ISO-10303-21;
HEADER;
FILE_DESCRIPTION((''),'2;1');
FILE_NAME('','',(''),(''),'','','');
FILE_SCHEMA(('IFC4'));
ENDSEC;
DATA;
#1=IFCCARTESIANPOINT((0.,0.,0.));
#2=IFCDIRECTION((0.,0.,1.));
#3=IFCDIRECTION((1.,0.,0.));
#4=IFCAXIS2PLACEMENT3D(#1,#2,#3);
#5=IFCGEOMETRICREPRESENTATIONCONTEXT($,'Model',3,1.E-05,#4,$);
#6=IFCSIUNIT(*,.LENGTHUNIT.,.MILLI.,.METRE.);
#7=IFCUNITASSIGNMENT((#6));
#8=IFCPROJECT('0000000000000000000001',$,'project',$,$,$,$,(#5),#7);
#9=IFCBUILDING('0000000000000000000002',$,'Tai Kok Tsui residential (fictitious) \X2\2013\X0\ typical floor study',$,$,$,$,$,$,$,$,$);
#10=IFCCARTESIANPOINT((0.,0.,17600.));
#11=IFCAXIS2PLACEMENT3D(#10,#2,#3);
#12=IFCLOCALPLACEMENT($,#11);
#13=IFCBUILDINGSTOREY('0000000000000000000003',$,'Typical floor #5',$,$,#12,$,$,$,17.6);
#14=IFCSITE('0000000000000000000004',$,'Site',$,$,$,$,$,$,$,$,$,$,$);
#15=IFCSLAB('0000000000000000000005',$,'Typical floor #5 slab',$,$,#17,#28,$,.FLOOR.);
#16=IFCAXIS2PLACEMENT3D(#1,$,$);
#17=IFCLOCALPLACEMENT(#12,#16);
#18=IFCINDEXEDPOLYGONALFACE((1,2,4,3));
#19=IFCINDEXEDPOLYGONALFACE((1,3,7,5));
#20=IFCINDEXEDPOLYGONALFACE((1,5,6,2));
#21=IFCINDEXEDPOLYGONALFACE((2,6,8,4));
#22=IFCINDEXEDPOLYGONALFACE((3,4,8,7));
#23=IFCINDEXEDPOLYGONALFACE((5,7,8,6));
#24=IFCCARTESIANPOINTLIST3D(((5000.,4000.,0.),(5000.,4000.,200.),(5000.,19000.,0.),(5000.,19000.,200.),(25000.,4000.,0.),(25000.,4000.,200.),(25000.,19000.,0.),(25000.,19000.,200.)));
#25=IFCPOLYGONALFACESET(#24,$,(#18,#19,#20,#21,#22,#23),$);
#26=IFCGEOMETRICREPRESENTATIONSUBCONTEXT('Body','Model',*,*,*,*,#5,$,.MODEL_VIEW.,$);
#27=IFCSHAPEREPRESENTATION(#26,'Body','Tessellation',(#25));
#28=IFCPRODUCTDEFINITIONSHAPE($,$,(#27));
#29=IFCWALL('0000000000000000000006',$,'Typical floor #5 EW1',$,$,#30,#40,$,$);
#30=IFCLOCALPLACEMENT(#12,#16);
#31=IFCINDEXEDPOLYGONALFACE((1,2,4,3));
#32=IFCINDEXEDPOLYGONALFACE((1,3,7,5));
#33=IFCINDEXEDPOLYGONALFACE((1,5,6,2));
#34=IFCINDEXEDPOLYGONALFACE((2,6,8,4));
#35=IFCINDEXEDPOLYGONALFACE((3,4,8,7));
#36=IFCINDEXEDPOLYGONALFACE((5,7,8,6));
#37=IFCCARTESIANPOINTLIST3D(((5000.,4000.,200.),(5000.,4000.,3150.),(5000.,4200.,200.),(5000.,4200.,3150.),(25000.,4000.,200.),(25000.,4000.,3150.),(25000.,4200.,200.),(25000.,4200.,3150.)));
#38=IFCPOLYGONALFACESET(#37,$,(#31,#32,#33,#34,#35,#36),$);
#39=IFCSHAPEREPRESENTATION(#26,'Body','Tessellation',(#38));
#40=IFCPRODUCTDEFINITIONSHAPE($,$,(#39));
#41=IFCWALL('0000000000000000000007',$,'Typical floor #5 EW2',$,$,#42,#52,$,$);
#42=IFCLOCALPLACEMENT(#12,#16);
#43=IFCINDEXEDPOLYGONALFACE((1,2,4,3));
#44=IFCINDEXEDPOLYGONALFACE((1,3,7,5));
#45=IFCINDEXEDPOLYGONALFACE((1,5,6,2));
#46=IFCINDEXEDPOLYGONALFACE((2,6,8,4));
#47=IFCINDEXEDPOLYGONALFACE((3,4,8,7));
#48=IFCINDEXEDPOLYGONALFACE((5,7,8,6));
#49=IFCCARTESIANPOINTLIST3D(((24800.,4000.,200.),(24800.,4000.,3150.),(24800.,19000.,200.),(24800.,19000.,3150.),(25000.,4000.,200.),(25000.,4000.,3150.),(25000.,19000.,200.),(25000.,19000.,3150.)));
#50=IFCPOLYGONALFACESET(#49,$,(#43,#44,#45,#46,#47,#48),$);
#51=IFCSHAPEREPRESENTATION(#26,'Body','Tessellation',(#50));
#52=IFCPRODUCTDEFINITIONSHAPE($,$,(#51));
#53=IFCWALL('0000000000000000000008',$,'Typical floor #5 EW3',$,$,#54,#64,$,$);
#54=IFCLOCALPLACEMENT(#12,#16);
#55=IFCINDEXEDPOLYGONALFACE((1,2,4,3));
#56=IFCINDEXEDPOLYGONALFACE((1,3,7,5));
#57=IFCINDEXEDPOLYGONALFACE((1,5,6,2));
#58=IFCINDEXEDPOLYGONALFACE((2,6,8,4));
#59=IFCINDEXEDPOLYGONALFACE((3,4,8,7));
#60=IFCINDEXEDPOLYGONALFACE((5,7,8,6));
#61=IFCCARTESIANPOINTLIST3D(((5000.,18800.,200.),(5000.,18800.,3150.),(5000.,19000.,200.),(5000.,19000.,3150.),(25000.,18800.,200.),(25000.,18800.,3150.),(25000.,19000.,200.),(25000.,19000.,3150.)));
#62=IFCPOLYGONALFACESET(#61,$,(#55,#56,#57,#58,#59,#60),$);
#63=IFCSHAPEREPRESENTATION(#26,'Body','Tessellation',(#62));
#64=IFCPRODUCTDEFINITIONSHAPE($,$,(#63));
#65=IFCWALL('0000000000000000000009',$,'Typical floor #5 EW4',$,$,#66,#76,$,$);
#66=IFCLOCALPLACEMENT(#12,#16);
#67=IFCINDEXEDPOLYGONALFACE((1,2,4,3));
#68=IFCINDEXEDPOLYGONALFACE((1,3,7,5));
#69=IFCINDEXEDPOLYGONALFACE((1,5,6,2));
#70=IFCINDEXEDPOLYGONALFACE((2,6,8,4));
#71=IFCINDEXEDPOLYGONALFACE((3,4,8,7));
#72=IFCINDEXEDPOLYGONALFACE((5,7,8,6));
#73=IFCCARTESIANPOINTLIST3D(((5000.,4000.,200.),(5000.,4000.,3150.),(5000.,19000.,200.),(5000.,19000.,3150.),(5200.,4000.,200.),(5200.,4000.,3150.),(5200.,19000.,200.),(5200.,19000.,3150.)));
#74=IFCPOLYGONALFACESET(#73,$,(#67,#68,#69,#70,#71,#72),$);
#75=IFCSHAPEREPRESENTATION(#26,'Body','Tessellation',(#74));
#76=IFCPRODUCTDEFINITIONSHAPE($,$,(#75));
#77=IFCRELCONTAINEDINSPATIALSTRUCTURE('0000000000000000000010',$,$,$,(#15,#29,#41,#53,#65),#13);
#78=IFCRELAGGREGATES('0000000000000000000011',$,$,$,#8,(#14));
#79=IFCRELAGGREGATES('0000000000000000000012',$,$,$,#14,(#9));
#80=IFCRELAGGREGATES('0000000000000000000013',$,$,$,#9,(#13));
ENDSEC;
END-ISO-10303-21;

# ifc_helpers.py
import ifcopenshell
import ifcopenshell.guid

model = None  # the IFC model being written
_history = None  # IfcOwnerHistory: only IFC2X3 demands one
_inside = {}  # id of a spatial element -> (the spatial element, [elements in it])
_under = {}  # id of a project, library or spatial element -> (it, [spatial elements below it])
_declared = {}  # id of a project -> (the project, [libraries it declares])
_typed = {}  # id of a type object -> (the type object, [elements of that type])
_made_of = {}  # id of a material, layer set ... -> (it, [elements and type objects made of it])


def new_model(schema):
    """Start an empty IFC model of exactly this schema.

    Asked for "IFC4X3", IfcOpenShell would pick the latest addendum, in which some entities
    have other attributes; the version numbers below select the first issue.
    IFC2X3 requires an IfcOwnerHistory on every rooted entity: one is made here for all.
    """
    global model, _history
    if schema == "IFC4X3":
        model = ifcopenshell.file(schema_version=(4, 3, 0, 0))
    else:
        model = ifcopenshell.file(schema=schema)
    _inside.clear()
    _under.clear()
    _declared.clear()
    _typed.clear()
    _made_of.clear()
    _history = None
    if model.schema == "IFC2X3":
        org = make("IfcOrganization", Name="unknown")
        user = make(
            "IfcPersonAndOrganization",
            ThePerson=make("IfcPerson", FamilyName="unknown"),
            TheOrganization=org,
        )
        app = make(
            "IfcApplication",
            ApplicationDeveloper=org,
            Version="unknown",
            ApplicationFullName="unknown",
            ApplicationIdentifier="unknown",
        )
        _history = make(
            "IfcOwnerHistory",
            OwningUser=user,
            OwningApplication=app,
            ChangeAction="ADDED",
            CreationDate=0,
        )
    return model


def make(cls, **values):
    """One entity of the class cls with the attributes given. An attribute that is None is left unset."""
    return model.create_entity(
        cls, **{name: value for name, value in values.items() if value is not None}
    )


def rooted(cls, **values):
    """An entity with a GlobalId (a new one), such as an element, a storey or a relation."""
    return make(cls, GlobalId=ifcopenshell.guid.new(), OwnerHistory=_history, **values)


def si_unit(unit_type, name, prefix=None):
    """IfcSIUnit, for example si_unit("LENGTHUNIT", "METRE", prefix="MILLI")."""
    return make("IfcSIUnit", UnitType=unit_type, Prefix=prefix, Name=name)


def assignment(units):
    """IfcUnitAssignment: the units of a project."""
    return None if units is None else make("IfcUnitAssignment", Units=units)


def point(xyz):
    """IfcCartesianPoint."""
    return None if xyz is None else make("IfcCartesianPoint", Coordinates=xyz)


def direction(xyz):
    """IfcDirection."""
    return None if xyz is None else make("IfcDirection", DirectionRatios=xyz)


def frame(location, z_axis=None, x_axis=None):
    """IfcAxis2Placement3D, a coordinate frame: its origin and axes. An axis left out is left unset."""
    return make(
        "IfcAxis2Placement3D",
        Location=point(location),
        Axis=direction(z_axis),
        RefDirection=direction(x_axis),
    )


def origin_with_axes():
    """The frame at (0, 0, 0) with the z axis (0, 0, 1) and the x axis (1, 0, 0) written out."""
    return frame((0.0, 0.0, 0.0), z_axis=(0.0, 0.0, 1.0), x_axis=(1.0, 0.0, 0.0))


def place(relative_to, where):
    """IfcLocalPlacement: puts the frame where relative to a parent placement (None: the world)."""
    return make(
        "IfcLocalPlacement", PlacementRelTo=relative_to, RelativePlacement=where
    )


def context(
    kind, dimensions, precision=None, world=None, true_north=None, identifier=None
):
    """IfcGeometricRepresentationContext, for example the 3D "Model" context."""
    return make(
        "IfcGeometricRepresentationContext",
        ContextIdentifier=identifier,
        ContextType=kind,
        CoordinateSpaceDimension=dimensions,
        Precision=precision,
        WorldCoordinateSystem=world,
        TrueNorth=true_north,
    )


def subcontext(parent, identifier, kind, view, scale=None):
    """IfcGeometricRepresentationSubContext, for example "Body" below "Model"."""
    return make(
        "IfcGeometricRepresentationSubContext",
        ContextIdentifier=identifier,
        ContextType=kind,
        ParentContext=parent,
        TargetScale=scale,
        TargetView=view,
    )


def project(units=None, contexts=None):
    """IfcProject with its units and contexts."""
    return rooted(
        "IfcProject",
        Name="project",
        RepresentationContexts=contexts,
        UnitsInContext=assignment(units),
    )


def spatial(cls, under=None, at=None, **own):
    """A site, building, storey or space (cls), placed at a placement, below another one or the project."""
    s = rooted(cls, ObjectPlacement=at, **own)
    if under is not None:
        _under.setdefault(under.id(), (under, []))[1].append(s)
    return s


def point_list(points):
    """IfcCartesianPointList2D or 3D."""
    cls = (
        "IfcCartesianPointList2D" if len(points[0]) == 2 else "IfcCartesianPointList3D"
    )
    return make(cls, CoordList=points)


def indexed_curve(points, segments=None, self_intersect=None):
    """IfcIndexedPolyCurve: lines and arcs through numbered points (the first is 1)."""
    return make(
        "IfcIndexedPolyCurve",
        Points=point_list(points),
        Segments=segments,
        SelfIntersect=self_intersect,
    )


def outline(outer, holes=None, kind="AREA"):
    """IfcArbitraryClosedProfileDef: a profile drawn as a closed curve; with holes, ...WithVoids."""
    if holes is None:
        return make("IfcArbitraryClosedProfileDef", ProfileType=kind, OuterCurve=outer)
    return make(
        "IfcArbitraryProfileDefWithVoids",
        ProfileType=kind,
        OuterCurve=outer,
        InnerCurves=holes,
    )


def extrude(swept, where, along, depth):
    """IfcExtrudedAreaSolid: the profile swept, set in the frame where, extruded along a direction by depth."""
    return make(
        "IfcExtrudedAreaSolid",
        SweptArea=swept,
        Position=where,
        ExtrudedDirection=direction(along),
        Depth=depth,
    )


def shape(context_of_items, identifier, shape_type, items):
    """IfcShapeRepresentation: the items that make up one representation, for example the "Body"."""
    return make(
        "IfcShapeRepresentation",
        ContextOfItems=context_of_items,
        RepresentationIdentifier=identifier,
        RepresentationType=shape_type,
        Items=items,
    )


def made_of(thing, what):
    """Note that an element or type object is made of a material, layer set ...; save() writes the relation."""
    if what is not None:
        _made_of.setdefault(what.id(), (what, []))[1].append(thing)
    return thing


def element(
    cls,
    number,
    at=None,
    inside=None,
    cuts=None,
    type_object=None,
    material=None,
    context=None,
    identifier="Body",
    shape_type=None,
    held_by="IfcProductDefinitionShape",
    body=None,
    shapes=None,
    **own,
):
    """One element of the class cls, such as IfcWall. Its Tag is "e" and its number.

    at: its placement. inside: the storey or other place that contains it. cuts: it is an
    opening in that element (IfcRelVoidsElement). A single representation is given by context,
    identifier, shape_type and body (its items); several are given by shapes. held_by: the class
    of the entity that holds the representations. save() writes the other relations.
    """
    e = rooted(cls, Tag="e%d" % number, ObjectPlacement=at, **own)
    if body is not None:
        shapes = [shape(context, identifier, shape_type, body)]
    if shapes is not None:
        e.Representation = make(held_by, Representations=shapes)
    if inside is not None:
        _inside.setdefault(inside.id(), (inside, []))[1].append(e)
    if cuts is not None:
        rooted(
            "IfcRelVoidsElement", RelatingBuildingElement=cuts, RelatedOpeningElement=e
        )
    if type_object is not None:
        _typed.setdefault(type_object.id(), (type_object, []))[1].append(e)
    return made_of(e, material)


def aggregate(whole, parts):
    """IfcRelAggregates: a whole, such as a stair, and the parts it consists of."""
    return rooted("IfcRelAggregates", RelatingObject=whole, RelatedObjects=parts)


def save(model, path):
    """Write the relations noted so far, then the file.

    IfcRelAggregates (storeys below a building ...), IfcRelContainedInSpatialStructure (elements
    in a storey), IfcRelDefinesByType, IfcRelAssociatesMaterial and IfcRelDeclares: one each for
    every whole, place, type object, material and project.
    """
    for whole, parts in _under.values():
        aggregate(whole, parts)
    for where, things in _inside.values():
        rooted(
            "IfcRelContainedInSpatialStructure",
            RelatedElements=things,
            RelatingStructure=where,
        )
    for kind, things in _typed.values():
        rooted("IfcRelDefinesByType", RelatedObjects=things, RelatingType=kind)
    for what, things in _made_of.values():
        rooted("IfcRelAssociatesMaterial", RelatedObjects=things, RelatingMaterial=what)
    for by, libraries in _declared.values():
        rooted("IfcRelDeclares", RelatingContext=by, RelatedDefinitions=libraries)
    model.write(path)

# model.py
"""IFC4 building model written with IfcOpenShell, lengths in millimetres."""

from ifc_helpers import new_model, si_unit, frame, origin_with_axes, place, context, subcontext, project, spatial, indexed_curve, outline, extrude, element, save


model = new_model("IFC4")

# Units and contexts
model_context = context("Model", 3, precision=1e-05, world=origin_with_axes())
body_context = subcontext(model_context, "Body", "Model", "MODEL_VIEW")
ifc_project = project(units=[si_unit("LENGTHUNIT", "METRE", prefix="MILLI")], contexts=[model_context])

# Site, building, storey
site = spatial("IfcSite", under=ifc_project, Name="Site")
building = spatial("IfcBuilding", under=site, Name="Tai Kok Tsui residential (fictitious) – typical floor study")
storey_placement = place(None, frame((0.0, 0.0, 17600.0), z_axis=(0.0, 0.0, 1.0), x_axis=(1.0, 0.0, 0.0)))
storey = spatial("IfcBuildingStorey", under=building, at=storey_placement, Name="Typical floor #5", Elevation=17.6)

# Slab
slab_placement = place(storey_placement, origin_with_axes())
element("IfcSlab", 1, at=slab_placement, inside=storey, Name="Typical floor #5 slab", PredefinedType="FLOOR", context=body_context, shape_type="SweptSolid", body=[
    extrude(outline(indexed_curve([(5000.0, 4000.0), (25000.0, 4000.0), (25000.0, 19000.0), (5000.0, 19000.0)])), None, (0.0, 0.0, 1.0), 200.0),
])

# Walls
wall_1_placement = place(storey_placement, frame((5000.0, 4000.0, 200.0), z_axis=(0.0, 0.0, 1.0), x_axis=(1.0, 0.0, 0.0)))
element("IfcWall", 2, at=wall_1_placement, inside=storey, Name="Typical floor #5 EW1", context=body_context, shape_type="SweptSolid", body=[
    extrude(outline(indexed_curve([(0.0, 0.0), (0.0, 200.0), (20000.0, 200.0), (20000.0, 0.0), (0.0, 0.0)], self_intersect=False)), origin_with_axes(), (0.0, 0.0, 1.0), 2950.0),
])
wall_2_placement = place(storey_placement, frame((25000.0, 4000.0, 200.0), z_axis=(0.0, 0.0, 1.0), x_axis=(0.0, 1.0, 0.0)))
element("IfcWall", 3, at=wall_2_placement, inside=storey, Name="Typical floor #5 EW2", context=body_context, shape_type="SweptSolid", body=[
    extrude(outline(indexed_curve([(0.0, 0.0), (0.0, 200.0), (15000.0, 200.0), (15000.0, 0.0), (0.0, 0.0)], self_intersect=False)), origin_with_axes(), (0.0, 0.0, 1.0), 2950.0),
])
wall_3_placement = place(storey_placement, frame((25000.0, 19000.0, 200.0), z_axis=(0.0, 0.0, 1.0), x_axis=(-1.0, 0.0, 0.0)))
element("IfcWall", 4, at=wall_3_placement, inside=storey, Name="Typical floor #5 EW3", context=body_context, shape_type="SweptSolid", body=[
    extrude(outline(indexed_curve([(0.0, 0.0), (0.0, 200.0), (20000.0, 200.0), (20000.0, 0.0), (0.0, 0.0)], self_intersect=False)), origin_with_axes(), (0.0, 0.0, 1.0), 2950.0),
])
wall_4_placement = place(storey_placement, frame((5000.0, 19000.0, 200.0), z_axis=(0.0, 0.0, 1.0), x_axis=(0.0, -1.0, 0.0)))
element("IfcWall", 5, at=wall_4_placement, inside=storey, Name="Typical floor #5 EW4", context=body_context, shape_type="SweptSolid", body=[
    extrude(outline(indexed_curve([(0.0, 0.0), (0.0, 200.0), (15000.0, 200.0), (15000.0, 0.0), (0.0, 0.0)], self_intersect=False)), origin_with_axes(), (0.0, 0.0, 1.0), 2950.0),
])

save(model, "model.ifc")
